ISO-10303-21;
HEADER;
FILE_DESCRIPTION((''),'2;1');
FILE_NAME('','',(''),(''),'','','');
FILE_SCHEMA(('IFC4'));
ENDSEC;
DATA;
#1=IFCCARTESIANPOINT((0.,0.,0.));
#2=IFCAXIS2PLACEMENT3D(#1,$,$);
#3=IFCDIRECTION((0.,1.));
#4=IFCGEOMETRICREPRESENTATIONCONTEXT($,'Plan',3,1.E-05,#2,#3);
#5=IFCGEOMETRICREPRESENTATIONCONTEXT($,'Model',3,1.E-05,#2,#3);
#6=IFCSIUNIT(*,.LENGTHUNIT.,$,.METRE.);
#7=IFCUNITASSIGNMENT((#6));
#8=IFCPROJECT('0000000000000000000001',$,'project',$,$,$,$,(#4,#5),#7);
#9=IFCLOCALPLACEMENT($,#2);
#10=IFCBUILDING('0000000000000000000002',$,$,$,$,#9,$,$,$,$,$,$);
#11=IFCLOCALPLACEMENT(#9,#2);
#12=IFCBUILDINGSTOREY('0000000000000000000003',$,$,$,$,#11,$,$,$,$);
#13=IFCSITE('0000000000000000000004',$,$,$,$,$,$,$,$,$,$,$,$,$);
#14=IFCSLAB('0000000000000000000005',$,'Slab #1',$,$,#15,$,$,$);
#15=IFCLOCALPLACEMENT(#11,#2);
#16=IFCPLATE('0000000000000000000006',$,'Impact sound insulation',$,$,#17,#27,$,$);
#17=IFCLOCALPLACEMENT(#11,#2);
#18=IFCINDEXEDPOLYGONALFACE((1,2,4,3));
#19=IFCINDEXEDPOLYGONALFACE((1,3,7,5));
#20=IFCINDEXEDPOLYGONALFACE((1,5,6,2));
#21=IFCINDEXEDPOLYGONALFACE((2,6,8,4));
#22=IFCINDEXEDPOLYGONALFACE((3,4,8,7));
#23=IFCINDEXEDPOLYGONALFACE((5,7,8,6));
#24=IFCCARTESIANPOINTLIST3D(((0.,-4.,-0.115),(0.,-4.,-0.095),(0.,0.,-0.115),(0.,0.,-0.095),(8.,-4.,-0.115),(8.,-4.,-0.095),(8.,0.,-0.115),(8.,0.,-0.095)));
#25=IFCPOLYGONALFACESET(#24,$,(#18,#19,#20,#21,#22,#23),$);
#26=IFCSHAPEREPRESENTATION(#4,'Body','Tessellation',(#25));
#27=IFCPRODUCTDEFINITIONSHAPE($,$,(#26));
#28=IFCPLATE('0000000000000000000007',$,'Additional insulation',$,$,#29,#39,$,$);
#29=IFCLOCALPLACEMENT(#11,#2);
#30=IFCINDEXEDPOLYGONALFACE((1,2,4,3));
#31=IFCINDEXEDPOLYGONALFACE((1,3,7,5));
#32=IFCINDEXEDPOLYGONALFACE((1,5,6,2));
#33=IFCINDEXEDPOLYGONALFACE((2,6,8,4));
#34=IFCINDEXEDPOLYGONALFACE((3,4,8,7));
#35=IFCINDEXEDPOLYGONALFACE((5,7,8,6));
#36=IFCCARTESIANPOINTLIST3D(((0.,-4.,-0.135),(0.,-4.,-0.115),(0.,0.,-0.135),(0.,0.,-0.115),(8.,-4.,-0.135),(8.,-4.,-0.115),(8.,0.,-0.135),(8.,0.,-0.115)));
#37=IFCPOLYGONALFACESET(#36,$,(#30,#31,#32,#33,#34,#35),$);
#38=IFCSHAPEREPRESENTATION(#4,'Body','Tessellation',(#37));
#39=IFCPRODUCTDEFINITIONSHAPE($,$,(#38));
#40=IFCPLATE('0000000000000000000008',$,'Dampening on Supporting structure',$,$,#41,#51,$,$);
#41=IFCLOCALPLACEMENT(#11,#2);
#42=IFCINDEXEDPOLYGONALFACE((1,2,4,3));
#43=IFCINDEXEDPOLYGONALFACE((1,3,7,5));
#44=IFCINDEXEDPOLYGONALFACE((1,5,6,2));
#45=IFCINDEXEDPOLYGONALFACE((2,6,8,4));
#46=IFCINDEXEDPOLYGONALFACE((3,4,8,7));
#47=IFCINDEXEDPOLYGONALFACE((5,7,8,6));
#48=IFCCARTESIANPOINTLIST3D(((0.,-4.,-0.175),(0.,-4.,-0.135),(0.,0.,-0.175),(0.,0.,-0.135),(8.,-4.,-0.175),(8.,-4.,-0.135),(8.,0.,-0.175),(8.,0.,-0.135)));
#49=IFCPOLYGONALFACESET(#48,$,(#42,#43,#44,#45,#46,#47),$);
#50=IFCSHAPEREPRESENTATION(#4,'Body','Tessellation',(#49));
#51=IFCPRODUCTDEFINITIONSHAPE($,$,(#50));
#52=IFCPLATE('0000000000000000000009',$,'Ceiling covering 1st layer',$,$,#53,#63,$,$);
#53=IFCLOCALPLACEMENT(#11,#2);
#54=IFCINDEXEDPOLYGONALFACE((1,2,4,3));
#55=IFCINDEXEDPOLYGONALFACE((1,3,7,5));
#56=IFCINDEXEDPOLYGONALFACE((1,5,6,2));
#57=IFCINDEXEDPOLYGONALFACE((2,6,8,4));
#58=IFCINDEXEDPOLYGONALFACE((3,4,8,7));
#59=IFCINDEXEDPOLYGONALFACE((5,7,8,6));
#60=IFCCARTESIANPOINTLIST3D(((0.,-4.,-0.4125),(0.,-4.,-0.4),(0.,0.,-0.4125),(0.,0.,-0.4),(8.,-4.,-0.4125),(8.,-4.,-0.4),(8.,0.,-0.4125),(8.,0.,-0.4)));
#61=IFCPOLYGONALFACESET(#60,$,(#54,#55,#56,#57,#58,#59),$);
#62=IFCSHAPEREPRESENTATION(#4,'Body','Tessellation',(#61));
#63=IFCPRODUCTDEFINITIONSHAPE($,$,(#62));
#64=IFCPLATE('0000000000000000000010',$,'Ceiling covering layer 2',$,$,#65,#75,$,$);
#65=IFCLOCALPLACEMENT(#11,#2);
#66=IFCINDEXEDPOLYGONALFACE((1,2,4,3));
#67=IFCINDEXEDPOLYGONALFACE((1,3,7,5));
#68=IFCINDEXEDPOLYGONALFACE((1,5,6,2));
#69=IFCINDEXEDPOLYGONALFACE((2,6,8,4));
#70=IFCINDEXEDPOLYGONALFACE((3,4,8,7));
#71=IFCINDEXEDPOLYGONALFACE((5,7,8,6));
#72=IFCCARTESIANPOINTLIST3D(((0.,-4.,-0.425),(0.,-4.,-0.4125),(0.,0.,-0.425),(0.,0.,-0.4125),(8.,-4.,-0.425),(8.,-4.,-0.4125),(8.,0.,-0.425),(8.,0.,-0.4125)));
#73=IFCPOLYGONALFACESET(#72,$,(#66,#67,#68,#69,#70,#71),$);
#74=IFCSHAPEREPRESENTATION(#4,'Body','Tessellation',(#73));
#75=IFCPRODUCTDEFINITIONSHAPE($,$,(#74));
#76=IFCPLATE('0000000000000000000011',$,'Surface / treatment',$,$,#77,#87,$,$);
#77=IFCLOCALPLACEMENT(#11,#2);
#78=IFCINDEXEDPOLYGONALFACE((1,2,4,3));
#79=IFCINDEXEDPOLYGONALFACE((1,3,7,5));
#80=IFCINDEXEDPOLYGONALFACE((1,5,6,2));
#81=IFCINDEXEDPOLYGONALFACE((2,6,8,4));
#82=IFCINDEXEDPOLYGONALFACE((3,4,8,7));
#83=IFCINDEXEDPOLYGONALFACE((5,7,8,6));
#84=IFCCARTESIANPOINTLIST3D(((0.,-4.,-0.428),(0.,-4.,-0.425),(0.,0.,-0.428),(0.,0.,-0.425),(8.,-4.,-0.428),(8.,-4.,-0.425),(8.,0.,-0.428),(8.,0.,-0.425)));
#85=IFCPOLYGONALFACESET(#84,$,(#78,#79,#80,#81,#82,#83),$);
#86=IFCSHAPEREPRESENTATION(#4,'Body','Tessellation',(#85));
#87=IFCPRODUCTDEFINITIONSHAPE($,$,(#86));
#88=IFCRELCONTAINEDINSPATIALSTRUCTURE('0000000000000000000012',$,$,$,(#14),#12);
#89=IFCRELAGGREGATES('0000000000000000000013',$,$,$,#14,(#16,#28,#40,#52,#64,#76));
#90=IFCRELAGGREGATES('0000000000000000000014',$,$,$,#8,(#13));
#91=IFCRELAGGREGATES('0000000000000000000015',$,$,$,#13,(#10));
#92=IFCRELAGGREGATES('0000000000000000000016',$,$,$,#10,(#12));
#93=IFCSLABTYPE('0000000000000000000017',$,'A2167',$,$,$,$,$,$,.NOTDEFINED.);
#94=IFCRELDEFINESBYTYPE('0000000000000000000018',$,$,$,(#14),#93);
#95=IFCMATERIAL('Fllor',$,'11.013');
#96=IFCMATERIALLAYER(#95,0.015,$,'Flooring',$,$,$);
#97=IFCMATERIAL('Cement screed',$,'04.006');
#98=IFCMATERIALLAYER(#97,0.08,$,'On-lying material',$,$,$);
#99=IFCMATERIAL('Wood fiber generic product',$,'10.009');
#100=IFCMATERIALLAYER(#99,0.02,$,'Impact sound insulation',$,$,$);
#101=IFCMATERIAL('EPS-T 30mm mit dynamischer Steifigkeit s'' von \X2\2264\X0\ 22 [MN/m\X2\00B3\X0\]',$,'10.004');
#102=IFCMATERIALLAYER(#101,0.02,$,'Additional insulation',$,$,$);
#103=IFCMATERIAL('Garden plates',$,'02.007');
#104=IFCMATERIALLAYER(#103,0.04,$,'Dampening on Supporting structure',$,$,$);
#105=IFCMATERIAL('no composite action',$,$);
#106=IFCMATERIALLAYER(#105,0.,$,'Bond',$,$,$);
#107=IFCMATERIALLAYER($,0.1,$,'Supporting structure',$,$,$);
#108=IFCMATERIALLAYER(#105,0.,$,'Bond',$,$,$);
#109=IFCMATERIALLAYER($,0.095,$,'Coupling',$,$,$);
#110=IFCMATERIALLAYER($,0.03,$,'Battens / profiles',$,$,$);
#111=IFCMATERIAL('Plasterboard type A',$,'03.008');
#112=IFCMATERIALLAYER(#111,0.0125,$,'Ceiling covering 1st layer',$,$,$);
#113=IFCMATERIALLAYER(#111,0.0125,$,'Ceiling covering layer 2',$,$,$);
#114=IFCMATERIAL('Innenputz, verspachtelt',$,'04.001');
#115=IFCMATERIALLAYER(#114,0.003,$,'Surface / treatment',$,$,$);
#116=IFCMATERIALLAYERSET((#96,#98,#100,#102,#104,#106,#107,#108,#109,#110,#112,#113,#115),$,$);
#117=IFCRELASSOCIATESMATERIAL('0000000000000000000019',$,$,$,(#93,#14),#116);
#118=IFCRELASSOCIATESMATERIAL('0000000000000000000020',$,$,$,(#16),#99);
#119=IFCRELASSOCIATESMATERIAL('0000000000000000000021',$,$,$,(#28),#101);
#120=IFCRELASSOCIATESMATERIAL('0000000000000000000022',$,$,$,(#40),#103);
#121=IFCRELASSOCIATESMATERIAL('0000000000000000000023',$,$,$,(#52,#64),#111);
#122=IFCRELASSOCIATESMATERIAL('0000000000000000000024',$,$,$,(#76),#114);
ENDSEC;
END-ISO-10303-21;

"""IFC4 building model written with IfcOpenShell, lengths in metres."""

from ifc_helpers import new_model, si_unit, direction, frame, frame_2d, origin, place, context, project, spatial, rectangle, extrude, material, layer, layer_set, type_object, element, aggregate, save


model = new_model("IFC4")

# Units and contexts
plan_context = context("Plan", 3, precision=1e-05, world=origin(), true_north=direction((0.0, 1.0)))
model_context = context("Model", 3, precision=1e-05, world=origin(), true_north=direction((0.0, 1.0)))
ifc_project = project(units=[si_unit("LENGTHUNIT", "METRE")], contexts=[plan_context, model_context])

# Site, building, storey
site = spatial("IfcSite", under=ifc_project)
building_placement = place(None, origin())
building = spatial("IfcBuilding", under=site, at=building_placement)
storey_placement = place(building_placement, origin())
storey = spatial("IfcBuildingStorey", under=building, at=storey_placement)

# Slab, plates
ifc_material_1 = material(Name="Fllor", Category="11.013")
ifc_layer_1 = layer(ifc_material_1, 0.015, Name="Flooring")
ifc_material_2 = material(Name="Cement screed", Category="04.006")
ifc_layer_2 = layer(ifc_material_2, 0.08, Name="On-lying material")
ifc_material_3 = material(Name="Wood fiber generic product", Category="10.009")
ifc_layer_3 = layer(ifc_material_3, 0.02, Name="Impact sound insulation")
ifc_material_4 = material(Name="EPS-T 30mm mit dynamischer Steifigkeit s' von ≤ 22 [MN/m³]", Category="10.004")
ifc_layer_4 = layer(ifc_material_4, 0.02, Name="Additional insulation")
ifc_material_5 = material(Name="Garden plates", Category="02.007")
ifc_layer_5 = layer(ifc_material_5, 0.04, Name="Dampening on Supporting structure")
ifc_material_6 = material(Name="no composite action")
ifc_layer_6 = layer(ifc_material_6, 0.0, Name="Bond")
ifc_layer_7 = layer(None, 0.1, Name="Supporting structure")
ifc_layer_8 = layer(ifc_material_6, 0.0, Name="Bond")
ifc_layer_9 = layer(None, 0.095, Name="Coupling")
ifc_layer_10 = layer(None, 0.03, Name="Battens / profiles")
ifc_material_7 = material(Name="Plasterboard type A", Category="03.008")
ifc_layer_11 = layer(ifc_material_7, 0.0125, Name="Ceiling covering 1st layer")
ifc_layer_12 = layer(ifc_material_7, 0.0125, Name="Ceiling covering layer 2")
ifc_material_8 = material(Name="Innenputz, verspachtelt", Category="04.001")
ifc_layer_13 = layer(ifc_material_8, 0.003, Name="Surface / treatment")
ifc_layer_set = layer_set([ifc_layer_1, ifc_layer_2, ifc_layer_3, ifc_layer_4, ifc_layer_5, ifc_layer_6, ifc_layer_7, ifc_layer_8, ifc_layer_9, ifc_layer_10, ifc_layer_11, ifc_layer_12, ifc_layer_13])
slab_type = type_object("IfcSlabType", Name="A2167", PredefinedType="NOTDEFINED", material=ifc_layer_set)
slab_placement = place(None, frame((0.0, 0.0, 0.0), z_axis=(0.0, 0.0, -1.0), x_axis=(1.0, 0.0, 0.0)))
slab = element("IfcSlab", 1, at=slab_placement, inside=storey, type_object=slab_type, material=ifc_layer_set, Name="Slab #1")
plate_1_placement = place(slab_placement, origin())
plate_1 = element("IfcPlate", 2, at=plate_1_placement, material=ifc_material_3, Name="Impact sound insulation", context=plan_context, shape_type="SweptSolid", body=[
    extrude(rectangle(XDim=8.0, YDim=4.0, at=frame_2d((4.0, 2.0), x_axis=(1.0, 0.0))), frame((0.0, 0.0, 0.095), z_axis=(0.0, 0.0, 1.0), x_axis=(1.0, 0.0, 0.0)), (0.0, 0.0, 1.0), 0.02),
])
plate_2_placement = place(slab_placement, origin())
plate_2 = element("IfcPlate", 3, at=plate_2_placement, material=ifc_material_4, Name="Additional insulation", context=plan_context, shape_type="SweptSolid", body=[
    extrude(rectangle(XDim=8.0, YDim=4.0, at=frame_2d((4.0, 2.0), x_axis=(1.0, 0.0))), frame((0.0, 0.0, 0.115), z_axis=(0.0, 0.0, 1.0), x_axis=(1.0, 0.0, 0.0)), (0.0, 0.0, 1.0), 0.02),
])
plate_3_placement = place(slab_placement, origin())
plate_3 = element("IfcPlate", 4, at=plate_3_placement, material=ifc_material_5, Name="Dampening on Supporting structure", context=plan_context, shape_type="SweptSolid", body=[
    extrude(rectangle(XDim=8.0, YDim=4.0, at=frame_2d((4.0, 2.0), x_axis=(1.0, 0.0))), frame((0.0, 0.0, 0.135), z_axis=(0.0, 0.0, 1.0), x_axis=(1.0, 0.0, 0.0)), (0.0, 0.0, 1.0), 0.04),
])
plate_4_placement = place(slab_placement, origin())
plate_4 = element("IfcPlate", 5, at=plate_4_placement, material=ifc_material_7, Name="Ceiling covering 1st layer", context=plan_context, shape_type="SweptSolid", body=[
    extrude(rectangle(XDim=8.0, YDim=4.0, at=frame_2d((4.0, 2.0), x_axis=(1.0, 0.0))), frame((0.0, 0.0, 0.4), z_axis=(0.0, 0.0, 1.0), x_axis=(1.0, 0.0, 0.0)), (0.0, 0.0, 1.0), 0.0125),
])
plate_5_placement = place(slab_placement, origin())
plate_5 = element("IfcPlate", 6, at=plate_5_placement, material=ifc_material_7, Name="Ceiling covering layer 2", context=plan_context, shape_type="SweptSolid", body=[
    extrude(rectangle(XDim=8.0, YDim=4.0, at=frame_2d((4.0, 2.0), x_axis=(1.0, 0.0))), frame((0.0, 0.0, 0.4125), z_axis=(0.0, 0.0, 1.0), x_axis=(1.0, 0.0, 0.0)), (0.0, 0.0, 1.0), 0.0125),
])
plate_6_placement = place(slab_placement, origin())
plate_6 = element("IfcPlate", 7, at=plate_6_placement, material=ifc_material_8, Name="Surface / treatment", context=plan_context, shape_type="SweptSolid", body=[
    extrude(rectangle(XDim=8.0, YDim=4.0, at=frame_2d((4.0, 2.0), x_axis=(1.0, 0.0))), frame((0.0, 0.0, 0.425), z_axis=(0.0, 0.0, 1.0), x_axis=(1.0, 0.0, 0.0)), (0.0, 0.0, 1.0), 0.003),
])
aggregate(slab, [plate_1, plate_2, plate_3, plate_4, plate_5, plate_6])

save(model, "model.ifc")
